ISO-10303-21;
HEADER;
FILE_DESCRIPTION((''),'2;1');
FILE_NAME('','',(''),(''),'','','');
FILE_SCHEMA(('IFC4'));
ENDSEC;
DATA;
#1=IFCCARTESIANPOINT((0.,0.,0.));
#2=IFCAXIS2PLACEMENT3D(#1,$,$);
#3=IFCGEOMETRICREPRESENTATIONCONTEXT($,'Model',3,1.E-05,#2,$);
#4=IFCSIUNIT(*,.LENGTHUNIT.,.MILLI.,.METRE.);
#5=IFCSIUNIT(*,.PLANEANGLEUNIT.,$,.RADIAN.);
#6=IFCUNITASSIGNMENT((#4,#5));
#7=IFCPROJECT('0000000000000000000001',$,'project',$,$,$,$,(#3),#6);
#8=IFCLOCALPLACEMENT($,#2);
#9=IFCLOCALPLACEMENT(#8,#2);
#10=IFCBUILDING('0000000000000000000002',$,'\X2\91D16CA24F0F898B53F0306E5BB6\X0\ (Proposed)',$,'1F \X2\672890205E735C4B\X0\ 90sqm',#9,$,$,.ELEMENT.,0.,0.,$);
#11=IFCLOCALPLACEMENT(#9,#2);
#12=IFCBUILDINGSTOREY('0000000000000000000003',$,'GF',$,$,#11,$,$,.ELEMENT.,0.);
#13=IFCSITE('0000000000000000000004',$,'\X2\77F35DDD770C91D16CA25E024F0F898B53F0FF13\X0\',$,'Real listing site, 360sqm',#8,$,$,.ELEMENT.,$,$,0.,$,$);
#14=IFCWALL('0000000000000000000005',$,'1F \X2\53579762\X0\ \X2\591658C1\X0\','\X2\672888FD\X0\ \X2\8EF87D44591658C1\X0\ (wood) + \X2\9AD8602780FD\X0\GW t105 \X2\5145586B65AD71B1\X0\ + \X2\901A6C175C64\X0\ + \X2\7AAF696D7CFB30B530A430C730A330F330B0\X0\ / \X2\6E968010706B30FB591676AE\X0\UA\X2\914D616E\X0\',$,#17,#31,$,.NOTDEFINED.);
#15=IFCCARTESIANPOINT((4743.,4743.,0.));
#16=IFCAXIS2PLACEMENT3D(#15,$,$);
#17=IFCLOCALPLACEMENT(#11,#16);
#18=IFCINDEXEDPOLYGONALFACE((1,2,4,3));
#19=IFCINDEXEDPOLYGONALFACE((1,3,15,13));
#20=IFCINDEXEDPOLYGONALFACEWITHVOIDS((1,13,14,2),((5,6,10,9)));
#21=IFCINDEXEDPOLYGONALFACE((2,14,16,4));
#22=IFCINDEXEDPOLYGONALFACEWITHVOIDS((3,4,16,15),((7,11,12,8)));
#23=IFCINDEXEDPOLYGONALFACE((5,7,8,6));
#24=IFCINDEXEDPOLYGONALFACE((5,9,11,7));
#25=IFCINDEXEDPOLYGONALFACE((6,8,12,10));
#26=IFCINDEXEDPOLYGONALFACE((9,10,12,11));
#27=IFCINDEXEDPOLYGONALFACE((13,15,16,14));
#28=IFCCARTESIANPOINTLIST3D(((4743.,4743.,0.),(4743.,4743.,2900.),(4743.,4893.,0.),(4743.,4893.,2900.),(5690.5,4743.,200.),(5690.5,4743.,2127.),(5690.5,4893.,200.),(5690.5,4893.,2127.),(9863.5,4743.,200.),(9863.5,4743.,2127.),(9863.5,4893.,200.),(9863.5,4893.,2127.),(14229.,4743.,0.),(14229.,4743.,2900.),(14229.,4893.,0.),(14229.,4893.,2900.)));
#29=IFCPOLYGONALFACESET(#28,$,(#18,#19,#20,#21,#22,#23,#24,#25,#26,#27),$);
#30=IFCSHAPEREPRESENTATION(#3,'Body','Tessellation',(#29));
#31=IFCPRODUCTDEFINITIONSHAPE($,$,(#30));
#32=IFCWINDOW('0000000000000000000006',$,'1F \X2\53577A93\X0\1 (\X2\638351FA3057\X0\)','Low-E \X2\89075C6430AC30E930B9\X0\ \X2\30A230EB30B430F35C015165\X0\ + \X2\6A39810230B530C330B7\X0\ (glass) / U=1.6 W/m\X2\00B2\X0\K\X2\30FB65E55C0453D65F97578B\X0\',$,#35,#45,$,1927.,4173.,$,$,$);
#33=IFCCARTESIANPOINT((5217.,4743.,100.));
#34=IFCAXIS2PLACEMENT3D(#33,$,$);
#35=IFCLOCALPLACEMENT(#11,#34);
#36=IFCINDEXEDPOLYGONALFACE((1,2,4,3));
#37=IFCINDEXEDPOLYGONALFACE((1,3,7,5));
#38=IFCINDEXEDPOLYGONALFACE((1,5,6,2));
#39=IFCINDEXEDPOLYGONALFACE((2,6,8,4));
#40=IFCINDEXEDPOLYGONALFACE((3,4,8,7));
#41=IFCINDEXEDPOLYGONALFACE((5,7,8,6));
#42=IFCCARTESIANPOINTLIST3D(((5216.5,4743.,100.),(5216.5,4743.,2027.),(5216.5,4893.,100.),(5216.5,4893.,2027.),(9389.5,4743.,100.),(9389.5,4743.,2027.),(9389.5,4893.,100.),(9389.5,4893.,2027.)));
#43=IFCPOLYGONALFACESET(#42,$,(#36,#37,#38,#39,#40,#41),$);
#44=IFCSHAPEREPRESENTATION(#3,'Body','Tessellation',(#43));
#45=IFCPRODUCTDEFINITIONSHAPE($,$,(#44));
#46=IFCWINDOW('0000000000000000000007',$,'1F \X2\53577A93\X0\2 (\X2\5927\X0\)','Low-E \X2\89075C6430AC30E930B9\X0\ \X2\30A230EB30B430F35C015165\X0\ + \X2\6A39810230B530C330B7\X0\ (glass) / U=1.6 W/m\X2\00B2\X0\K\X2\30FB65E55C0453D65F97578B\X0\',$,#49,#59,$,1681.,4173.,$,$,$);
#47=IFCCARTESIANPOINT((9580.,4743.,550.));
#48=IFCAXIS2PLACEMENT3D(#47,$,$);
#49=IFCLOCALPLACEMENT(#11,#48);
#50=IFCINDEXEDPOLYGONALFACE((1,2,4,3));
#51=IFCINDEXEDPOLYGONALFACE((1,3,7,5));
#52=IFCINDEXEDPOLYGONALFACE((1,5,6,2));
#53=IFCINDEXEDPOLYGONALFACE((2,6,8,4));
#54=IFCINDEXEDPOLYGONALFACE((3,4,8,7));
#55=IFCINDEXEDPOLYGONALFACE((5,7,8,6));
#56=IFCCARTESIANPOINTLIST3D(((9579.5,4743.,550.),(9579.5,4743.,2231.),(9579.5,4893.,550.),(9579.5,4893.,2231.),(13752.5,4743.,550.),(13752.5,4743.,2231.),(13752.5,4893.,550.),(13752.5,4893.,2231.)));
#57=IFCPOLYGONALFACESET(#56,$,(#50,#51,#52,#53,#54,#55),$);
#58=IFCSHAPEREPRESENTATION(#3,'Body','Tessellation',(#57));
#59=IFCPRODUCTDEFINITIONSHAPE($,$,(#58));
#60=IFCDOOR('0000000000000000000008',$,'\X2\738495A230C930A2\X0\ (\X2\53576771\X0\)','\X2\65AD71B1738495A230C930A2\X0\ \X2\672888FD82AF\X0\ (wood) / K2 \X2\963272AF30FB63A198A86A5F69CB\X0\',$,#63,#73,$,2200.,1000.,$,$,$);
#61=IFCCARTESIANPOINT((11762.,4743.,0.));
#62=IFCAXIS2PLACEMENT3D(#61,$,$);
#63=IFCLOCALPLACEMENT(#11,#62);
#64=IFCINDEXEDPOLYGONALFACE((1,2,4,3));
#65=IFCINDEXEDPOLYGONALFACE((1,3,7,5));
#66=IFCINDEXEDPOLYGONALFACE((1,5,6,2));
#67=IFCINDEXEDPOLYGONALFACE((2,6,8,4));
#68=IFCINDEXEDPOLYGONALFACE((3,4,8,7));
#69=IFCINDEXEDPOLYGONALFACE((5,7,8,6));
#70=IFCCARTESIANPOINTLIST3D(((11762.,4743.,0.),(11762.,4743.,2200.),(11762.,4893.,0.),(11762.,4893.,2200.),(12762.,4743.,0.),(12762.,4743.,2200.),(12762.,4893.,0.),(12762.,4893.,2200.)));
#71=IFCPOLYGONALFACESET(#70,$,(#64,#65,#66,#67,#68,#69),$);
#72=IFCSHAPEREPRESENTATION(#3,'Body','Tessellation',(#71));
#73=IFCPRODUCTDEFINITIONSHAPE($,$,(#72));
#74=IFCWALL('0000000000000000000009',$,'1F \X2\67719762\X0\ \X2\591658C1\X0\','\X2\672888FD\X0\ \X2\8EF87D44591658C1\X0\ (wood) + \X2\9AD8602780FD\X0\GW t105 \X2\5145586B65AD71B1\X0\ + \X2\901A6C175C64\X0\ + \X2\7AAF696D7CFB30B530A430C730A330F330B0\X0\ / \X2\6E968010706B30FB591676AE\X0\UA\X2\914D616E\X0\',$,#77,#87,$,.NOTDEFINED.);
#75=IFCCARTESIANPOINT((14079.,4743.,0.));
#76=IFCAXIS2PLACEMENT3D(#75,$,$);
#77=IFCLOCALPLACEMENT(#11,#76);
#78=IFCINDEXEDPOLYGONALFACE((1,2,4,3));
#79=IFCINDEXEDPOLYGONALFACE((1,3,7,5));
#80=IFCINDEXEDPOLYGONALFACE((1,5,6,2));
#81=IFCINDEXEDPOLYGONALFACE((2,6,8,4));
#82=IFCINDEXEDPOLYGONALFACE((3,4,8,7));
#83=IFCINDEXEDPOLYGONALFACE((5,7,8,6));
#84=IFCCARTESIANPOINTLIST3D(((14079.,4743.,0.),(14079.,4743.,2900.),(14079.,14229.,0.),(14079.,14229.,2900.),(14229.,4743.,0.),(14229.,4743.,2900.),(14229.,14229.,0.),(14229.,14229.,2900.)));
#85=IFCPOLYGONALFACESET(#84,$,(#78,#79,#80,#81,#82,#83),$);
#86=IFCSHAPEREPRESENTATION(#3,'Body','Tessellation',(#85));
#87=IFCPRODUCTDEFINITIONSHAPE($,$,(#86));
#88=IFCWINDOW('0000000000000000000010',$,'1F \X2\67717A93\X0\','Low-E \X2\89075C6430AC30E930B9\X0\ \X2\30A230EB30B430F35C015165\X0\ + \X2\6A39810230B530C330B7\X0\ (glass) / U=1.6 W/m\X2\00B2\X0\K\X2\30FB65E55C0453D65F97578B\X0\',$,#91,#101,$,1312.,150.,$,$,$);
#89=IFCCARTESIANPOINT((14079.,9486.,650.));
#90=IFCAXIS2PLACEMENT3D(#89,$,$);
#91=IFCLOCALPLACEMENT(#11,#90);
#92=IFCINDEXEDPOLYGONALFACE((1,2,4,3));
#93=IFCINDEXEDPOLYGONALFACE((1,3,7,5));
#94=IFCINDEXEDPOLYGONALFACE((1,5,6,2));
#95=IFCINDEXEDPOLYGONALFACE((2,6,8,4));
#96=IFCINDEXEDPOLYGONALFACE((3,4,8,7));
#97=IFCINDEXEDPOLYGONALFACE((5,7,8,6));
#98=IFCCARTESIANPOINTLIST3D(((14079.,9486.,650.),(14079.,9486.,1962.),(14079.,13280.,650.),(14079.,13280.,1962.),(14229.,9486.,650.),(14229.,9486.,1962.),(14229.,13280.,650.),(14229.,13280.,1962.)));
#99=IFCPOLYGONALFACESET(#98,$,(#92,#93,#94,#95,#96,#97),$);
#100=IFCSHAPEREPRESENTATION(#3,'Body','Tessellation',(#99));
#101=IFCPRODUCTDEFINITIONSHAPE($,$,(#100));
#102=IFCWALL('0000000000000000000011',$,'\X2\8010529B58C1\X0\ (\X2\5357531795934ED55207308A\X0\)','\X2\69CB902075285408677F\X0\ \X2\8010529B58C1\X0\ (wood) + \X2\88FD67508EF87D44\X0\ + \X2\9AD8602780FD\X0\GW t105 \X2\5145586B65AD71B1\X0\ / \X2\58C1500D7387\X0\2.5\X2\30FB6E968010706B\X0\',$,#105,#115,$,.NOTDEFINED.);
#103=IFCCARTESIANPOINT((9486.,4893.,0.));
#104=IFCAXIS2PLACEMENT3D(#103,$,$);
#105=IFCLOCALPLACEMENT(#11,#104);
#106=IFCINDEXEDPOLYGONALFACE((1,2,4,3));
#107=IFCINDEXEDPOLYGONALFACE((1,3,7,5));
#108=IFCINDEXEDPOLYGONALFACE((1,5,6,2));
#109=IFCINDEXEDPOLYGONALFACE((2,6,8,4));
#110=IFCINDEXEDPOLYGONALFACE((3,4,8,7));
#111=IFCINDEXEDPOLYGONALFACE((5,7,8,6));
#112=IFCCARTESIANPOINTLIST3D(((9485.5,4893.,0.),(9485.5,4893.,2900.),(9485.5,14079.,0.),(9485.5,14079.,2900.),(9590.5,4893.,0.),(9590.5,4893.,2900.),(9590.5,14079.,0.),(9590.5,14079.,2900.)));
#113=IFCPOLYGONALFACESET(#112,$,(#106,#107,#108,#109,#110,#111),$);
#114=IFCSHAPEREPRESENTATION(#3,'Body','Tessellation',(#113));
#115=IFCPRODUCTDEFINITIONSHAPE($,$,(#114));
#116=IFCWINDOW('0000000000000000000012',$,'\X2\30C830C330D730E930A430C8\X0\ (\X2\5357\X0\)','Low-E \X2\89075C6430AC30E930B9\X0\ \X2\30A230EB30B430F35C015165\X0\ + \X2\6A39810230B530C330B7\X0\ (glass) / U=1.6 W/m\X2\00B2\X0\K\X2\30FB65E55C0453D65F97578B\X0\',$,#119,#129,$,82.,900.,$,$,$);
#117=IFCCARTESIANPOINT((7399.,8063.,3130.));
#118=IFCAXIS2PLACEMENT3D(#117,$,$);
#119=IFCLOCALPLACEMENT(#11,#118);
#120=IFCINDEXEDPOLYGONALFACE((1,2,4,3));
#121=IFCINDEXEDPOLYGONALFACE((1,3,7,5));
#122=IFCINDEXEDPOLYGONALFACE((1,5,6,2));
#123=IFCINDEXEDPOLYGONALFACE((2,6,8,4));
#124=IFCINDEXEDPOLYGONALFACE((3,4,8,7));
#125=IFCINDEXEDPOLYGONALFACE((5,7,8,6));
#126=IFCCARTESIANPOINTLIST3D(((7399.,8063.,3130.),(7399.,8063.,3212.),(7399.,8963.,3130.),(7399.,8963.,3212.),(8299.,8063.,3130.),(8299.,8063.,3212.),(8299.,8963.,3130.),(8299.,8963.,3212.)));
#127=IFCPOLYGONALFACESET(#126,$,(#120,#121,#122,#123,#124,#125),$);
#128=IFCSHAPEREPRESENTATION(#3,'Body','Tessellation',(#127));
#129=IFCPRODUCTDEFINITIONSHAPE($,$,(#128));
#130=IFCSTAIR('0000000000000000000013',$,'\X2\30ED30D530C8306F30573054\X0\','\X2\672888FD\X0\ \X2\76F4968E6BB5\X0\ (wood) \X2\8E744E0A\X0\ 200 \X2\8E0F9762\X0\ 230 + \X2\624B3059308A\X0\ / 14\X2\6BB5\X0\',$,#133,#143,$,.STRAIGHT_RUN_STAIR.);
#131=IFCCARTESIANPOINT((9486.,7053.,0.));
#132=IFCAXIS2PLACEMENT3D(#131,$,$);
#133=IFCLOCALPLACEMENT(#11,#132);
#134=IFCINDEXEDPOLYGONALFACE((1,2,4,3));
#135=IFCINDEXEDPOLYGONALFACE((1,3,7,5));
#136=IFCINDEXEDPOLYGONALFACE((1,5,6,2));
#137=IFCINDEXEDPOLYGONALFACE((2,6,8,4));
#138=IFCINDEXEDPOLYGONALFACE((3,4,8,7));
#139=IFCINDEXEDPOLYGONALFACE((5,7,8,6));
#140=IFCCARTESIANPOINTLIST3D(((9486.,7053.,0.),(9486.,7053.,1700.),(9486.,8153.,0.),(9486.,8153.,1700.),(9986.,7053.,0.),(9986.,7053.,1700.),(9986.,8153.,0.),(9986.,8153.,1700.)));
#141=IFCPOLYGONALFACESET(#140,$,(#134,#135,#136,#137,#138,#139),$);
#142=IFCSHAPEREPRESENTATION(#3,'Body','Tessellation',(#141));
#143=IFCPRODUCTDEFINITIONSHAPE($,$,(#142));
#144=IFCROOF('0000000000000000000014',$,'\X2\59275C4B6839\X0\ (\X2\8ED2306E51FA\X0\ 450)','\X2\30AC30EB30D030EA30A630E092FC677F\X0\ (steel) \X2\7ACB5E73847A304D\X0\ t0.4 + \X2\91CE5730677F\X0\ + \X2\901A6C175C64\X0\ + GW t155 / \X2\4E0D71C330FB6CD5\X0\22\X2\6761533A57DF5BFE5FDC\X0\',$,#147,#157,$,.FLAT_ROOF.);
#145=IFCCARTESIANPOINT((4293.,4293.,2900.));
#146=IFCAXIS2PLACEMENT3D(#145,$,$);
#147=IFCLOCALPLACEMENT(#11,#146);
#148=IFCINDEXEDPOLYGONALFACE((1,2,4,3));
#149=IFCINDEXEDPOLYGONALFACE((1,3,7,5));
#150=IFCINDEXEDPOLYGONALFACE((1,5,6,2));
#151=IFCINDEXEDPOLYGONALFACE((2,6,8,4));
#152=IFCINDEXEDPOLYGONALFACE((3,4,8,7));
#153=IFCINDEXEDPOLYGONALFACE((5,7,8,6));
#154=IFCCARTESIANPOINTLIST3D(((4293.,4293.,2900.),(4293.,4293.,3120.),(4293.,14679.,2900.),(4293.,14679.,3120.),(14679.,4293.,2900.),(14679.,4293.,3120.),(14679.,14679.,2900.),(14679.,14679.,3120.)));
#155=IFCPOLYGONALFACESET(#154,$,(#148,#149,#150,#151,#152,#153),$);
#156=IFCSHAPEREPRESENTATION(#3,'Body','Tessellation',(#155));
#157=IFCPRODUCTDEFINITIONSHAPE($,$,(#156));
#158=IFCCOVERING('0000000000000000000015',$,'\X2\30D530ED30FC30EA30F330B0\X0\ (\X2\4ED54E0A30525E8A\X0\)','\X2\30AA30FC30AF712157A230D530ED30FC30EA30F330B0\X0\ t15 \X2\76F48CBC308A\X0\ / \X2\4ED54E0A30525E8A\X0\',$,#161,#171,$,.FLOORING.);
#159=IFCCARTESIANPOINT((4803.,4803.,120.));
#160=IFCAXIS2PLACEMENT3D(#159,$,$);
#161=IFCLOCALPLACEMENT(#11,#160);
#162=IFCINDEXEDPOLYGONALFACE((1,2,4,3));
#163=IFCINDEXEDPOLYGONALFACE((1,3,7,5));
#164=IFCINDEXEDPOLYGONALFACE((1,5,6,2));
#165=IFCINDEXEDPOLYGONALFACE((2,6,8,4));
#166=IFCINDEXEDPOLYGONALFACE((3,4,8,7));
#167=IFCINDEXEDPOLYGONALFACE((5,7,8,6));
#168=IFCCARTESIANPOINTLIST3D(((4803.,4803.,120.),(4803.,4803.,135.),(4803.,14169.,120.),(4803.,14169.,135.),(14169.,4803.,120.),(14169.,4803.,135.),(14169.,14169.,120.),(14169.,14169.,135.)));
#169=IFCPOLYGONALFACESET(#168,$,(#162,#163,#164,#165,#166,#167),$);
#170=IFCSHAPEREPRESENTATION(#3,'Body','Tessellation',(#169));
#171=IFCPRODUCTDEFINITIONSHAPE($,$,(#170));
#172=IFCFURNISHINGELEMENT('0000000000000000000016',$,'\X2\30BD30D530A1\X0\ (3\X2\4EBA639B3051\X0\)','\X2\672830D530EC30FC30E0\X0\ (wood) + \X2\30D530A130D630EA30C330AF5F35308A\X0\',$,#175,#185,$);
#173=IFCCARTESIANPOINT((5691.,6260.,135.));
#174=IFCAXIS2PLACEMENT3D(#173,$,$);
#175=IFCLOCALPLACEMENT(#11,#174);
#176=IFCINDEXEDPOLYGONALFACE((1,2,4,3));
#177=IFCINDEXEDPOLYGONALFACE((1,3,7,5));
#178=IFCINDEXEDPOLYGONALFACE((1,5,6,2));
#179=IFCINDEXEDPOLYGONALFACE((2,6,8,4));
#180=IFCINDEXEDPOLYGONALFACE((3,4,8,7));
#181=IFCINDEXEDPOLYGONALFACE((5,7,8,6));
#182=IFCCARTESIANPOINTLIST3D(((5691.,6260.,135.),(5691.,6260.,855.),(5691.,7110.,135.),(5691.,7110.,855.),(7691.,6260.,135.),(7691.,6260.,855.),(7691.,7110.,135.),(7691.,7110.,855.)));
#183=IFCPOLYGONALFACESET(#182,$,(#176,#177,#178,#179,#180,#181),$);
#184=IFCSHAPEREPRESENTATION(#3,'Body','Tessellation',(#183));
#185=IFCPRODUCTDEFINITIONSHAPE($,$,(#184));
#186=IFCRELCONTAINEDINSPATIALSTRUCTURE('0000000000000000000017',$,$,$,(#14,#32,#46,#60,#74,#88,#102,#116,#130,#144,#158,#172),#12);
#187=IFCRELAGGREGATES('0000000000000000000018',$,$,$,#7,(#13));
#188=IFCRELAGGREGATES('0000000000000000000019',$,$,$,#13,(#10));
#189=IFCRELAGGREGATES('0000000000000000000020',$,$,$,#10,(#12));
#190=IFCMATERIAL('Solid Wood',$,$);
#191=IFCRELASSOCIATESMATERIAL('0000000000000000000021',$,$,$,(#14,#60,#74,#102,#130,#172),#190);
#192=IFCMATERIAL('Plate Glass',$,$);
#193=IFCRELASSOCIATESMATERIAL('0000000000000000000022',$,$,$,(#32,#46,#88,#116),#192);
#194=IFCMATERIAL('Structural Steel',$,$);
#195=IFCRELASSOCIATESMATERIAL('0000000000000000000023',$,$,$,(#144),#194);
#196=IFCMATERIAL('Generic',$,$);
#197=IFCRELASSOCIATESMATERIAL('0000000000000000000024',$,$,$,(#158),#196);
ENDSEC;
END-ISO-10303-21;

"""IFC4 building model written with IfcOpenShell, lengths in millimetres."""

from ifc_helpers import new_model, si_unit, frame, frame_2d, origin, place, context, project, spatial, rectangle, extrude, material, element, fill, save


model = new_model("IFC4")

# Units and contexts
model_context = context("Model", 3, precision=1e-05, world=origin())
ifc_project = project(units=[si_unit("LENGTHUNIT", "METRE", prefix="MILLI"), si_unit("PLANEANGLEUNIT", "RADIAN")], contexts=[model_context])

# Site, building, storey
site_placement = place(None, origin())
site = spatial("IfcSite", under=ifc_project, at=site_placement, Name="石川県金沢市伏見台３", ObjectType="Real listing site, 360sqm", CompositionType="ELEMENT", RefElevation=0.0)
building_placement = place(site_placement, origin())
building = spatial("IfcBuilding", under=site, at=building_placement, Name="金沢伏見台の家 (Proposed)", ObjectType="1F 木造平屋 90sqm", CompositionType="ELEMENT", ElevationOfRefHeight=0.0, ElevationOfTerrain=0.0)
storey_placement = place(building_placement, origin())
storey = spatial("IfcBuildingStorey", under=building, at=storey_placement, Name="GF", CompositionType="ELEMENT", Elevation=0.0)

# Shared definitions
ifc_material_1 = material(Name="Solid Wood")

# Wall, openings, windows, door
wall_1_placement = place(storey_placement, frame((4743.0, 4743.0, 0.0)))
wall_1 = element("IfcWall", 1, at=wall_1_placement, inside=storey, material=ifc_material_1, Name="1F 南面 外壁", Description="木製 軸組外壁 (wood) + 高性能GW t105 充填断熱 + 通気層 + 窯業系サイディング / 準耐火・外皮UA配慮", PredefinedType="NOTDEFINED", context=model_context, shape_type="SweptSolid", body=[
    extrude(rectangle(XDim=9486.0, YDim=150.0, at=frame_2d((4743.0, 75.0))), frame((4743.0, 4743.0, 0.0)), (0.0, 0.0, 1.0), 2900.0),
])
opening_1_placement = place(storey_placement, frame((5217.0, 4743.0, 100.0)))
opening_1 = element("IfcOpeningElement", 2, at=opening_1_placement, cuts=wall_1, PredefinedType="NOTDEFINED", context=model_context, shape_type="SweptSolid", body=[
    extrude(rectangle(XDim=4173.0, YDim=150.0, at=frame_2d((2086.0, 75.0))), frame((5217.0, 4743.0, 100.0)), (0.0, 0.0, 1.0), 1927.0),
])
opening_2_placement = place(storey_placement, frame((9580.0, 4743.0, 550.0)))
opening_2 = element("IfcOpeningElement", 3, at=opening_2_placement, cuts=wall_1, PredefinedType="NOTDEFINED", context=model_context, shape_type="SweptSolid", body=[
    extrude(rectangle(XDim=4173.0, YDim=150.0, at=frame_2d((2086.0, 75.0))), frame((9580.0, 4743.0, 550.0)), (0.0, 0.0, 1.0), 1681.0),
])
opening_3_placement = place(storey_placement, frame((11762.0, 4743.0, 0.0)))
opening_3 = element("IfcOpeningElement", 4, at=opening_3_placement, cuts=wall_1, PredefinedType="NOTDEFINED", context=model_context, shape_type="SweptSolid", body=[
    extrude(rectangle(XDim=1000.0, YDim=150.0, at=frame_2d((500.0, 75.0))), frame((11762.0, 4743.0, 0.0)), (0.0, 0.0, 1.0), 2200.0),
])
ifc_material_2 = material(Name="Plate Glass")
window_1_placement = place(storey_placement, frame((5217.0, 4743.0, 100.0)))
window_1 = element("IfcWindow", 5, at=window_1_placement, inside=storey, material=ifc_material_2, Name="1F 南窓1 (掃出し)", Description="Low-E 複層ガラス アルゴン封入 + 樹脂サッシ (glass) / U=1.6 W/m²K・日射取得型", OverallHeight=1927.0, OverallWidth=4173.0, context=model_context, shape_type="SweptSolid", body=[
    extrude(rectangle(XDim=4173.0, YDim=150.0, at=frame_2d((2086.0, 75.0))), frame((5217.0, 4743.0, 100.0)), (0.0, 0.0, 1.0), 1927.0),
])
fill(opening_1, window_1)
window_2_placement = place(storey_placement, frame((9580.0, 4743.0, 550.0)))
window_2 = element("IfcWindow", 6, at=window_2_placement, inside=storey, material=ifc_material_2, Name="1F 南窓2 (大)", Description="Low-E 複層ガラス アルゴン封入 + 樹脂サッシ (glass) / U=1.6 W/m²K・日射取得型", OverallHeight=1681.0, OverallWidth=4173.0, context=model_context, shape_type="SweptSolid", body=[
    extrude(rectangle(XDim=4173.0, YDim=150.0, at=frame_2d((2086.0, 75.0))), frame((9580.0, 4743.0, 550.0)), (0.0, 0.0, 1.0), 1681.0),
])
fill(opening_2, window_2)
door_placement = place(storey_placement, frame((11762.0, 4743.0, 0.0)))
door = element("IfcDoor", 7, at=door_placement, inside=storey, material=ifc_material_1, Name="玄関ドア (南東)", Description="断熱玄関ドア 木製芯 (wood) / K2 防犯・採風機構", OverallHeight=2200.0, OverallWidth=1000.0, context=model_context, shape_type="SweptSolid", body=[
    extrude(rectangle(XDim=1000.0, YDim=150.0, at=frame_2d((500.0, 75.0))), frame((11762.0, 4743.0, 0.0)), (0.0, 0.0, 1.0), 2200.0),
])
fill(opening_3, door)

# Wall, opening, window
wall_2_placement = place(storey_placement, frame((14079.0, 4743.0, 0.0)))
wall_2 = element("IfcWall", 8, at=wall_2_placement, inside=storey, material=ifc_material_1, Name="1F 東面 外壁", Description="木製 軸組外壁 (wood) + 高性能GW t105 充填断熱 + 通気層 + 窯業系サイディング / 準耐火・外皮UA配慮", PredefinedType="NOTDEFINED", context=model_context, shape_type="SweptSolid", body=[
    extrude(rectangle(XDim=150.0, YDim=9486.0, at=frame_2d((75.0, 4743.0))), frame((14079.0, 4743.0, 0.0)), (0.0, 0.0, 1.0), 2900.0),
])
opening_4_placement = place(storey_placement, frame((14079.0, 9486.0, 650.0)))
opening_4 = element("IfcOpeningElement", 9, at=opening_4_placement, cuts=wall_2, PredefinedType="NOTDEFINED", context=model_context, shape_type="SweptSolid", body=[
    extrude(rectangle(XDim=150.0, YDim=3794.0, at=frame_2d((75.0, 1897.0))), frame((14079.0, 9486.0, 650.0)), (0.0, 0.0, 1.0), 1312.0),
])
window_3_placement = place(storey_placement, frame((14079.0, 9486.0, 650.0)))
window_3 = element("IfcWindow", 10, at=window_3_placement, inside=storey, material=ifc_material_2, Name="1F 東窓", Description="Low-E 複層ガラス アルゴン封入 + 樹脂サッシ (glass) / U=1.6 W/m²K・日射取得型", OverallHeight=1312.0, OverallWidth=150.0, context=model_context, shape_type="SweptSolid", body=[
    extrude(rectangle(XDim=150.0, YDim=3794.0, at=frame_2d((75.0, 1897.0))), frame((14079.0, 9486.0, 650.0)), (0.0, 0.0, 1.0), 1312.0),
])
fill(opening_4, window_3)

# Wall
wall_3_placement = place(storey_placement, frame((9486.0, 4893.0, 0.0)))
element("IfcWall", 11, at=wall_3_placement, inside=storey, material=ifc_material_1, Name="耐力壁 (南北間仕切り)", Description="構造用合板 耐力壁 (wood) + 製材軸組 + 高性能GW t105 充填断熱 / 壁倍率2.5・準耐火", PredefinedType="NOTDEFINED", context=model_context, shape_type="SweptSolid", body=[
    extrude(rectangle(XDim=105.0, YDim=9186.0, at=frame_2d((52.0, 4593.0))), frame((9486.0, 4893.0, 0.0)), (0.0, 0.0, 1.0), 2900.0),
])

# Window
window_4_placement = place(storey_placement, frame((7399.0, 8063.0, 3130.0)))
element("IfcWindow", 12, at=window_4_placement, inside=storey, material=ifc_material_2, Name="トップライト (南)", Description="Low-E 複層ガラス アルゴン封入 + 樹脂サッシ (glass) / U=1.6 W/m²K・日射取得型", OverallHeight=82.0, OverallWidth=900.0, context=model_context, shape_type="SweptSolid", body=[
    extrude(rectangle(XDim=900.0, YDim=900.0, at=frame_2d((450.0, 450.0))), frame((7399.0, 8063.0, 3130.0)), (0.0, 0.0, 1.0), 82.0),
])

# Stair
stair_placement = place(storey_placement, frame((9486.0, 7053.0, 0.0)))
element("IfcStair", 13, at=stair_placement, inside=storey, material=ifc_material_1, Name="ロフトはしご", Description="木製 直階段 (wood) 蹴上 200 踏面 230 + 手すり / 14段", PredefinedType="STRAIGHT_RUN_STAIR", context=model_context, shape_type="SweptSolid", body=[
    extrude(rectangle(XDim=500.0, YDim=1100.0, at=frame_2d((250.0, 550.0))), frame((9486.0, 7053.0, 0.0)), (0.0, 0.0, 1.0), 1700.0),
])

# Roof
ifc_material_3 = material(Name="Structural Steel")
roof_placement = place(storey_placement, frame((4293.0, 4293.0, 2900.0)))
element("IfcRoof", 14, at=roof_placement, inside=storey, material=ifc_material_3, Name="大屋根 (軒の出 450)", Description="ガルバリウム鋼板 (steel) 立平葺き t0.4 + 野地板 + 通気層 + GW t155 / 不燃・法22条区域対応", PredefinedType="FLAT_ROOF", context=model_context, shape_type="SweptSolid", body=[
    extrude(rectangle(XDim=10386.0, YDim=10386.0, at=frame_2d((5193.0, 5193.0))), frame((4293.0, 4293.0, 2900.0)), (0.0, 0.0, 1.0), 220.0),
])

# Covering
ifc_material_4 = material(Name="Generic")
covering_placement = place(storey_placement, frame((4803.0, 4803.0, 120.0)))
element("IfcCovering", 15, at=covering_placement, inside=storey, material=ifc_material_4, Name="フローリング (仕上げ床)", Description="オーク無垢フローリング t15 直貼り / 仕上げ床", PredefinedType="FLOORING", context=model_context, shape_type="SweptSolid", body=[
    extrude(rectangle(XDim=9366.0, YDim=9366.0, at=frame_2d((4683.0, 4683.0))), frame((4803.0, 4803.0, 120.0)), (0.0, 0.0, 1.0), 15.0),
])

# Furnishing element
furnishing_1_placement = place(storey_placement, frame((5691.0, 6260.0, 135.0)))
element("IfcFurnishingElement", 16, at=furnishing_1_placement, inside=storey, material=ifc_material_1, Name="ソファ (3人掛け)", Description="木フレーム (wood) + ファブリック張り", context=model_context, shape_type="SweptSolid", body=[
    extrude(rectangle(XDim=2000.0, YDim=850.0, at=frame_2d((1000.0, 425.0))), frame((5691.0, 6260.0, 135.0)), (0.0, 0.0, 1.0), 720.0),
])

save(model, "model.ifc")
